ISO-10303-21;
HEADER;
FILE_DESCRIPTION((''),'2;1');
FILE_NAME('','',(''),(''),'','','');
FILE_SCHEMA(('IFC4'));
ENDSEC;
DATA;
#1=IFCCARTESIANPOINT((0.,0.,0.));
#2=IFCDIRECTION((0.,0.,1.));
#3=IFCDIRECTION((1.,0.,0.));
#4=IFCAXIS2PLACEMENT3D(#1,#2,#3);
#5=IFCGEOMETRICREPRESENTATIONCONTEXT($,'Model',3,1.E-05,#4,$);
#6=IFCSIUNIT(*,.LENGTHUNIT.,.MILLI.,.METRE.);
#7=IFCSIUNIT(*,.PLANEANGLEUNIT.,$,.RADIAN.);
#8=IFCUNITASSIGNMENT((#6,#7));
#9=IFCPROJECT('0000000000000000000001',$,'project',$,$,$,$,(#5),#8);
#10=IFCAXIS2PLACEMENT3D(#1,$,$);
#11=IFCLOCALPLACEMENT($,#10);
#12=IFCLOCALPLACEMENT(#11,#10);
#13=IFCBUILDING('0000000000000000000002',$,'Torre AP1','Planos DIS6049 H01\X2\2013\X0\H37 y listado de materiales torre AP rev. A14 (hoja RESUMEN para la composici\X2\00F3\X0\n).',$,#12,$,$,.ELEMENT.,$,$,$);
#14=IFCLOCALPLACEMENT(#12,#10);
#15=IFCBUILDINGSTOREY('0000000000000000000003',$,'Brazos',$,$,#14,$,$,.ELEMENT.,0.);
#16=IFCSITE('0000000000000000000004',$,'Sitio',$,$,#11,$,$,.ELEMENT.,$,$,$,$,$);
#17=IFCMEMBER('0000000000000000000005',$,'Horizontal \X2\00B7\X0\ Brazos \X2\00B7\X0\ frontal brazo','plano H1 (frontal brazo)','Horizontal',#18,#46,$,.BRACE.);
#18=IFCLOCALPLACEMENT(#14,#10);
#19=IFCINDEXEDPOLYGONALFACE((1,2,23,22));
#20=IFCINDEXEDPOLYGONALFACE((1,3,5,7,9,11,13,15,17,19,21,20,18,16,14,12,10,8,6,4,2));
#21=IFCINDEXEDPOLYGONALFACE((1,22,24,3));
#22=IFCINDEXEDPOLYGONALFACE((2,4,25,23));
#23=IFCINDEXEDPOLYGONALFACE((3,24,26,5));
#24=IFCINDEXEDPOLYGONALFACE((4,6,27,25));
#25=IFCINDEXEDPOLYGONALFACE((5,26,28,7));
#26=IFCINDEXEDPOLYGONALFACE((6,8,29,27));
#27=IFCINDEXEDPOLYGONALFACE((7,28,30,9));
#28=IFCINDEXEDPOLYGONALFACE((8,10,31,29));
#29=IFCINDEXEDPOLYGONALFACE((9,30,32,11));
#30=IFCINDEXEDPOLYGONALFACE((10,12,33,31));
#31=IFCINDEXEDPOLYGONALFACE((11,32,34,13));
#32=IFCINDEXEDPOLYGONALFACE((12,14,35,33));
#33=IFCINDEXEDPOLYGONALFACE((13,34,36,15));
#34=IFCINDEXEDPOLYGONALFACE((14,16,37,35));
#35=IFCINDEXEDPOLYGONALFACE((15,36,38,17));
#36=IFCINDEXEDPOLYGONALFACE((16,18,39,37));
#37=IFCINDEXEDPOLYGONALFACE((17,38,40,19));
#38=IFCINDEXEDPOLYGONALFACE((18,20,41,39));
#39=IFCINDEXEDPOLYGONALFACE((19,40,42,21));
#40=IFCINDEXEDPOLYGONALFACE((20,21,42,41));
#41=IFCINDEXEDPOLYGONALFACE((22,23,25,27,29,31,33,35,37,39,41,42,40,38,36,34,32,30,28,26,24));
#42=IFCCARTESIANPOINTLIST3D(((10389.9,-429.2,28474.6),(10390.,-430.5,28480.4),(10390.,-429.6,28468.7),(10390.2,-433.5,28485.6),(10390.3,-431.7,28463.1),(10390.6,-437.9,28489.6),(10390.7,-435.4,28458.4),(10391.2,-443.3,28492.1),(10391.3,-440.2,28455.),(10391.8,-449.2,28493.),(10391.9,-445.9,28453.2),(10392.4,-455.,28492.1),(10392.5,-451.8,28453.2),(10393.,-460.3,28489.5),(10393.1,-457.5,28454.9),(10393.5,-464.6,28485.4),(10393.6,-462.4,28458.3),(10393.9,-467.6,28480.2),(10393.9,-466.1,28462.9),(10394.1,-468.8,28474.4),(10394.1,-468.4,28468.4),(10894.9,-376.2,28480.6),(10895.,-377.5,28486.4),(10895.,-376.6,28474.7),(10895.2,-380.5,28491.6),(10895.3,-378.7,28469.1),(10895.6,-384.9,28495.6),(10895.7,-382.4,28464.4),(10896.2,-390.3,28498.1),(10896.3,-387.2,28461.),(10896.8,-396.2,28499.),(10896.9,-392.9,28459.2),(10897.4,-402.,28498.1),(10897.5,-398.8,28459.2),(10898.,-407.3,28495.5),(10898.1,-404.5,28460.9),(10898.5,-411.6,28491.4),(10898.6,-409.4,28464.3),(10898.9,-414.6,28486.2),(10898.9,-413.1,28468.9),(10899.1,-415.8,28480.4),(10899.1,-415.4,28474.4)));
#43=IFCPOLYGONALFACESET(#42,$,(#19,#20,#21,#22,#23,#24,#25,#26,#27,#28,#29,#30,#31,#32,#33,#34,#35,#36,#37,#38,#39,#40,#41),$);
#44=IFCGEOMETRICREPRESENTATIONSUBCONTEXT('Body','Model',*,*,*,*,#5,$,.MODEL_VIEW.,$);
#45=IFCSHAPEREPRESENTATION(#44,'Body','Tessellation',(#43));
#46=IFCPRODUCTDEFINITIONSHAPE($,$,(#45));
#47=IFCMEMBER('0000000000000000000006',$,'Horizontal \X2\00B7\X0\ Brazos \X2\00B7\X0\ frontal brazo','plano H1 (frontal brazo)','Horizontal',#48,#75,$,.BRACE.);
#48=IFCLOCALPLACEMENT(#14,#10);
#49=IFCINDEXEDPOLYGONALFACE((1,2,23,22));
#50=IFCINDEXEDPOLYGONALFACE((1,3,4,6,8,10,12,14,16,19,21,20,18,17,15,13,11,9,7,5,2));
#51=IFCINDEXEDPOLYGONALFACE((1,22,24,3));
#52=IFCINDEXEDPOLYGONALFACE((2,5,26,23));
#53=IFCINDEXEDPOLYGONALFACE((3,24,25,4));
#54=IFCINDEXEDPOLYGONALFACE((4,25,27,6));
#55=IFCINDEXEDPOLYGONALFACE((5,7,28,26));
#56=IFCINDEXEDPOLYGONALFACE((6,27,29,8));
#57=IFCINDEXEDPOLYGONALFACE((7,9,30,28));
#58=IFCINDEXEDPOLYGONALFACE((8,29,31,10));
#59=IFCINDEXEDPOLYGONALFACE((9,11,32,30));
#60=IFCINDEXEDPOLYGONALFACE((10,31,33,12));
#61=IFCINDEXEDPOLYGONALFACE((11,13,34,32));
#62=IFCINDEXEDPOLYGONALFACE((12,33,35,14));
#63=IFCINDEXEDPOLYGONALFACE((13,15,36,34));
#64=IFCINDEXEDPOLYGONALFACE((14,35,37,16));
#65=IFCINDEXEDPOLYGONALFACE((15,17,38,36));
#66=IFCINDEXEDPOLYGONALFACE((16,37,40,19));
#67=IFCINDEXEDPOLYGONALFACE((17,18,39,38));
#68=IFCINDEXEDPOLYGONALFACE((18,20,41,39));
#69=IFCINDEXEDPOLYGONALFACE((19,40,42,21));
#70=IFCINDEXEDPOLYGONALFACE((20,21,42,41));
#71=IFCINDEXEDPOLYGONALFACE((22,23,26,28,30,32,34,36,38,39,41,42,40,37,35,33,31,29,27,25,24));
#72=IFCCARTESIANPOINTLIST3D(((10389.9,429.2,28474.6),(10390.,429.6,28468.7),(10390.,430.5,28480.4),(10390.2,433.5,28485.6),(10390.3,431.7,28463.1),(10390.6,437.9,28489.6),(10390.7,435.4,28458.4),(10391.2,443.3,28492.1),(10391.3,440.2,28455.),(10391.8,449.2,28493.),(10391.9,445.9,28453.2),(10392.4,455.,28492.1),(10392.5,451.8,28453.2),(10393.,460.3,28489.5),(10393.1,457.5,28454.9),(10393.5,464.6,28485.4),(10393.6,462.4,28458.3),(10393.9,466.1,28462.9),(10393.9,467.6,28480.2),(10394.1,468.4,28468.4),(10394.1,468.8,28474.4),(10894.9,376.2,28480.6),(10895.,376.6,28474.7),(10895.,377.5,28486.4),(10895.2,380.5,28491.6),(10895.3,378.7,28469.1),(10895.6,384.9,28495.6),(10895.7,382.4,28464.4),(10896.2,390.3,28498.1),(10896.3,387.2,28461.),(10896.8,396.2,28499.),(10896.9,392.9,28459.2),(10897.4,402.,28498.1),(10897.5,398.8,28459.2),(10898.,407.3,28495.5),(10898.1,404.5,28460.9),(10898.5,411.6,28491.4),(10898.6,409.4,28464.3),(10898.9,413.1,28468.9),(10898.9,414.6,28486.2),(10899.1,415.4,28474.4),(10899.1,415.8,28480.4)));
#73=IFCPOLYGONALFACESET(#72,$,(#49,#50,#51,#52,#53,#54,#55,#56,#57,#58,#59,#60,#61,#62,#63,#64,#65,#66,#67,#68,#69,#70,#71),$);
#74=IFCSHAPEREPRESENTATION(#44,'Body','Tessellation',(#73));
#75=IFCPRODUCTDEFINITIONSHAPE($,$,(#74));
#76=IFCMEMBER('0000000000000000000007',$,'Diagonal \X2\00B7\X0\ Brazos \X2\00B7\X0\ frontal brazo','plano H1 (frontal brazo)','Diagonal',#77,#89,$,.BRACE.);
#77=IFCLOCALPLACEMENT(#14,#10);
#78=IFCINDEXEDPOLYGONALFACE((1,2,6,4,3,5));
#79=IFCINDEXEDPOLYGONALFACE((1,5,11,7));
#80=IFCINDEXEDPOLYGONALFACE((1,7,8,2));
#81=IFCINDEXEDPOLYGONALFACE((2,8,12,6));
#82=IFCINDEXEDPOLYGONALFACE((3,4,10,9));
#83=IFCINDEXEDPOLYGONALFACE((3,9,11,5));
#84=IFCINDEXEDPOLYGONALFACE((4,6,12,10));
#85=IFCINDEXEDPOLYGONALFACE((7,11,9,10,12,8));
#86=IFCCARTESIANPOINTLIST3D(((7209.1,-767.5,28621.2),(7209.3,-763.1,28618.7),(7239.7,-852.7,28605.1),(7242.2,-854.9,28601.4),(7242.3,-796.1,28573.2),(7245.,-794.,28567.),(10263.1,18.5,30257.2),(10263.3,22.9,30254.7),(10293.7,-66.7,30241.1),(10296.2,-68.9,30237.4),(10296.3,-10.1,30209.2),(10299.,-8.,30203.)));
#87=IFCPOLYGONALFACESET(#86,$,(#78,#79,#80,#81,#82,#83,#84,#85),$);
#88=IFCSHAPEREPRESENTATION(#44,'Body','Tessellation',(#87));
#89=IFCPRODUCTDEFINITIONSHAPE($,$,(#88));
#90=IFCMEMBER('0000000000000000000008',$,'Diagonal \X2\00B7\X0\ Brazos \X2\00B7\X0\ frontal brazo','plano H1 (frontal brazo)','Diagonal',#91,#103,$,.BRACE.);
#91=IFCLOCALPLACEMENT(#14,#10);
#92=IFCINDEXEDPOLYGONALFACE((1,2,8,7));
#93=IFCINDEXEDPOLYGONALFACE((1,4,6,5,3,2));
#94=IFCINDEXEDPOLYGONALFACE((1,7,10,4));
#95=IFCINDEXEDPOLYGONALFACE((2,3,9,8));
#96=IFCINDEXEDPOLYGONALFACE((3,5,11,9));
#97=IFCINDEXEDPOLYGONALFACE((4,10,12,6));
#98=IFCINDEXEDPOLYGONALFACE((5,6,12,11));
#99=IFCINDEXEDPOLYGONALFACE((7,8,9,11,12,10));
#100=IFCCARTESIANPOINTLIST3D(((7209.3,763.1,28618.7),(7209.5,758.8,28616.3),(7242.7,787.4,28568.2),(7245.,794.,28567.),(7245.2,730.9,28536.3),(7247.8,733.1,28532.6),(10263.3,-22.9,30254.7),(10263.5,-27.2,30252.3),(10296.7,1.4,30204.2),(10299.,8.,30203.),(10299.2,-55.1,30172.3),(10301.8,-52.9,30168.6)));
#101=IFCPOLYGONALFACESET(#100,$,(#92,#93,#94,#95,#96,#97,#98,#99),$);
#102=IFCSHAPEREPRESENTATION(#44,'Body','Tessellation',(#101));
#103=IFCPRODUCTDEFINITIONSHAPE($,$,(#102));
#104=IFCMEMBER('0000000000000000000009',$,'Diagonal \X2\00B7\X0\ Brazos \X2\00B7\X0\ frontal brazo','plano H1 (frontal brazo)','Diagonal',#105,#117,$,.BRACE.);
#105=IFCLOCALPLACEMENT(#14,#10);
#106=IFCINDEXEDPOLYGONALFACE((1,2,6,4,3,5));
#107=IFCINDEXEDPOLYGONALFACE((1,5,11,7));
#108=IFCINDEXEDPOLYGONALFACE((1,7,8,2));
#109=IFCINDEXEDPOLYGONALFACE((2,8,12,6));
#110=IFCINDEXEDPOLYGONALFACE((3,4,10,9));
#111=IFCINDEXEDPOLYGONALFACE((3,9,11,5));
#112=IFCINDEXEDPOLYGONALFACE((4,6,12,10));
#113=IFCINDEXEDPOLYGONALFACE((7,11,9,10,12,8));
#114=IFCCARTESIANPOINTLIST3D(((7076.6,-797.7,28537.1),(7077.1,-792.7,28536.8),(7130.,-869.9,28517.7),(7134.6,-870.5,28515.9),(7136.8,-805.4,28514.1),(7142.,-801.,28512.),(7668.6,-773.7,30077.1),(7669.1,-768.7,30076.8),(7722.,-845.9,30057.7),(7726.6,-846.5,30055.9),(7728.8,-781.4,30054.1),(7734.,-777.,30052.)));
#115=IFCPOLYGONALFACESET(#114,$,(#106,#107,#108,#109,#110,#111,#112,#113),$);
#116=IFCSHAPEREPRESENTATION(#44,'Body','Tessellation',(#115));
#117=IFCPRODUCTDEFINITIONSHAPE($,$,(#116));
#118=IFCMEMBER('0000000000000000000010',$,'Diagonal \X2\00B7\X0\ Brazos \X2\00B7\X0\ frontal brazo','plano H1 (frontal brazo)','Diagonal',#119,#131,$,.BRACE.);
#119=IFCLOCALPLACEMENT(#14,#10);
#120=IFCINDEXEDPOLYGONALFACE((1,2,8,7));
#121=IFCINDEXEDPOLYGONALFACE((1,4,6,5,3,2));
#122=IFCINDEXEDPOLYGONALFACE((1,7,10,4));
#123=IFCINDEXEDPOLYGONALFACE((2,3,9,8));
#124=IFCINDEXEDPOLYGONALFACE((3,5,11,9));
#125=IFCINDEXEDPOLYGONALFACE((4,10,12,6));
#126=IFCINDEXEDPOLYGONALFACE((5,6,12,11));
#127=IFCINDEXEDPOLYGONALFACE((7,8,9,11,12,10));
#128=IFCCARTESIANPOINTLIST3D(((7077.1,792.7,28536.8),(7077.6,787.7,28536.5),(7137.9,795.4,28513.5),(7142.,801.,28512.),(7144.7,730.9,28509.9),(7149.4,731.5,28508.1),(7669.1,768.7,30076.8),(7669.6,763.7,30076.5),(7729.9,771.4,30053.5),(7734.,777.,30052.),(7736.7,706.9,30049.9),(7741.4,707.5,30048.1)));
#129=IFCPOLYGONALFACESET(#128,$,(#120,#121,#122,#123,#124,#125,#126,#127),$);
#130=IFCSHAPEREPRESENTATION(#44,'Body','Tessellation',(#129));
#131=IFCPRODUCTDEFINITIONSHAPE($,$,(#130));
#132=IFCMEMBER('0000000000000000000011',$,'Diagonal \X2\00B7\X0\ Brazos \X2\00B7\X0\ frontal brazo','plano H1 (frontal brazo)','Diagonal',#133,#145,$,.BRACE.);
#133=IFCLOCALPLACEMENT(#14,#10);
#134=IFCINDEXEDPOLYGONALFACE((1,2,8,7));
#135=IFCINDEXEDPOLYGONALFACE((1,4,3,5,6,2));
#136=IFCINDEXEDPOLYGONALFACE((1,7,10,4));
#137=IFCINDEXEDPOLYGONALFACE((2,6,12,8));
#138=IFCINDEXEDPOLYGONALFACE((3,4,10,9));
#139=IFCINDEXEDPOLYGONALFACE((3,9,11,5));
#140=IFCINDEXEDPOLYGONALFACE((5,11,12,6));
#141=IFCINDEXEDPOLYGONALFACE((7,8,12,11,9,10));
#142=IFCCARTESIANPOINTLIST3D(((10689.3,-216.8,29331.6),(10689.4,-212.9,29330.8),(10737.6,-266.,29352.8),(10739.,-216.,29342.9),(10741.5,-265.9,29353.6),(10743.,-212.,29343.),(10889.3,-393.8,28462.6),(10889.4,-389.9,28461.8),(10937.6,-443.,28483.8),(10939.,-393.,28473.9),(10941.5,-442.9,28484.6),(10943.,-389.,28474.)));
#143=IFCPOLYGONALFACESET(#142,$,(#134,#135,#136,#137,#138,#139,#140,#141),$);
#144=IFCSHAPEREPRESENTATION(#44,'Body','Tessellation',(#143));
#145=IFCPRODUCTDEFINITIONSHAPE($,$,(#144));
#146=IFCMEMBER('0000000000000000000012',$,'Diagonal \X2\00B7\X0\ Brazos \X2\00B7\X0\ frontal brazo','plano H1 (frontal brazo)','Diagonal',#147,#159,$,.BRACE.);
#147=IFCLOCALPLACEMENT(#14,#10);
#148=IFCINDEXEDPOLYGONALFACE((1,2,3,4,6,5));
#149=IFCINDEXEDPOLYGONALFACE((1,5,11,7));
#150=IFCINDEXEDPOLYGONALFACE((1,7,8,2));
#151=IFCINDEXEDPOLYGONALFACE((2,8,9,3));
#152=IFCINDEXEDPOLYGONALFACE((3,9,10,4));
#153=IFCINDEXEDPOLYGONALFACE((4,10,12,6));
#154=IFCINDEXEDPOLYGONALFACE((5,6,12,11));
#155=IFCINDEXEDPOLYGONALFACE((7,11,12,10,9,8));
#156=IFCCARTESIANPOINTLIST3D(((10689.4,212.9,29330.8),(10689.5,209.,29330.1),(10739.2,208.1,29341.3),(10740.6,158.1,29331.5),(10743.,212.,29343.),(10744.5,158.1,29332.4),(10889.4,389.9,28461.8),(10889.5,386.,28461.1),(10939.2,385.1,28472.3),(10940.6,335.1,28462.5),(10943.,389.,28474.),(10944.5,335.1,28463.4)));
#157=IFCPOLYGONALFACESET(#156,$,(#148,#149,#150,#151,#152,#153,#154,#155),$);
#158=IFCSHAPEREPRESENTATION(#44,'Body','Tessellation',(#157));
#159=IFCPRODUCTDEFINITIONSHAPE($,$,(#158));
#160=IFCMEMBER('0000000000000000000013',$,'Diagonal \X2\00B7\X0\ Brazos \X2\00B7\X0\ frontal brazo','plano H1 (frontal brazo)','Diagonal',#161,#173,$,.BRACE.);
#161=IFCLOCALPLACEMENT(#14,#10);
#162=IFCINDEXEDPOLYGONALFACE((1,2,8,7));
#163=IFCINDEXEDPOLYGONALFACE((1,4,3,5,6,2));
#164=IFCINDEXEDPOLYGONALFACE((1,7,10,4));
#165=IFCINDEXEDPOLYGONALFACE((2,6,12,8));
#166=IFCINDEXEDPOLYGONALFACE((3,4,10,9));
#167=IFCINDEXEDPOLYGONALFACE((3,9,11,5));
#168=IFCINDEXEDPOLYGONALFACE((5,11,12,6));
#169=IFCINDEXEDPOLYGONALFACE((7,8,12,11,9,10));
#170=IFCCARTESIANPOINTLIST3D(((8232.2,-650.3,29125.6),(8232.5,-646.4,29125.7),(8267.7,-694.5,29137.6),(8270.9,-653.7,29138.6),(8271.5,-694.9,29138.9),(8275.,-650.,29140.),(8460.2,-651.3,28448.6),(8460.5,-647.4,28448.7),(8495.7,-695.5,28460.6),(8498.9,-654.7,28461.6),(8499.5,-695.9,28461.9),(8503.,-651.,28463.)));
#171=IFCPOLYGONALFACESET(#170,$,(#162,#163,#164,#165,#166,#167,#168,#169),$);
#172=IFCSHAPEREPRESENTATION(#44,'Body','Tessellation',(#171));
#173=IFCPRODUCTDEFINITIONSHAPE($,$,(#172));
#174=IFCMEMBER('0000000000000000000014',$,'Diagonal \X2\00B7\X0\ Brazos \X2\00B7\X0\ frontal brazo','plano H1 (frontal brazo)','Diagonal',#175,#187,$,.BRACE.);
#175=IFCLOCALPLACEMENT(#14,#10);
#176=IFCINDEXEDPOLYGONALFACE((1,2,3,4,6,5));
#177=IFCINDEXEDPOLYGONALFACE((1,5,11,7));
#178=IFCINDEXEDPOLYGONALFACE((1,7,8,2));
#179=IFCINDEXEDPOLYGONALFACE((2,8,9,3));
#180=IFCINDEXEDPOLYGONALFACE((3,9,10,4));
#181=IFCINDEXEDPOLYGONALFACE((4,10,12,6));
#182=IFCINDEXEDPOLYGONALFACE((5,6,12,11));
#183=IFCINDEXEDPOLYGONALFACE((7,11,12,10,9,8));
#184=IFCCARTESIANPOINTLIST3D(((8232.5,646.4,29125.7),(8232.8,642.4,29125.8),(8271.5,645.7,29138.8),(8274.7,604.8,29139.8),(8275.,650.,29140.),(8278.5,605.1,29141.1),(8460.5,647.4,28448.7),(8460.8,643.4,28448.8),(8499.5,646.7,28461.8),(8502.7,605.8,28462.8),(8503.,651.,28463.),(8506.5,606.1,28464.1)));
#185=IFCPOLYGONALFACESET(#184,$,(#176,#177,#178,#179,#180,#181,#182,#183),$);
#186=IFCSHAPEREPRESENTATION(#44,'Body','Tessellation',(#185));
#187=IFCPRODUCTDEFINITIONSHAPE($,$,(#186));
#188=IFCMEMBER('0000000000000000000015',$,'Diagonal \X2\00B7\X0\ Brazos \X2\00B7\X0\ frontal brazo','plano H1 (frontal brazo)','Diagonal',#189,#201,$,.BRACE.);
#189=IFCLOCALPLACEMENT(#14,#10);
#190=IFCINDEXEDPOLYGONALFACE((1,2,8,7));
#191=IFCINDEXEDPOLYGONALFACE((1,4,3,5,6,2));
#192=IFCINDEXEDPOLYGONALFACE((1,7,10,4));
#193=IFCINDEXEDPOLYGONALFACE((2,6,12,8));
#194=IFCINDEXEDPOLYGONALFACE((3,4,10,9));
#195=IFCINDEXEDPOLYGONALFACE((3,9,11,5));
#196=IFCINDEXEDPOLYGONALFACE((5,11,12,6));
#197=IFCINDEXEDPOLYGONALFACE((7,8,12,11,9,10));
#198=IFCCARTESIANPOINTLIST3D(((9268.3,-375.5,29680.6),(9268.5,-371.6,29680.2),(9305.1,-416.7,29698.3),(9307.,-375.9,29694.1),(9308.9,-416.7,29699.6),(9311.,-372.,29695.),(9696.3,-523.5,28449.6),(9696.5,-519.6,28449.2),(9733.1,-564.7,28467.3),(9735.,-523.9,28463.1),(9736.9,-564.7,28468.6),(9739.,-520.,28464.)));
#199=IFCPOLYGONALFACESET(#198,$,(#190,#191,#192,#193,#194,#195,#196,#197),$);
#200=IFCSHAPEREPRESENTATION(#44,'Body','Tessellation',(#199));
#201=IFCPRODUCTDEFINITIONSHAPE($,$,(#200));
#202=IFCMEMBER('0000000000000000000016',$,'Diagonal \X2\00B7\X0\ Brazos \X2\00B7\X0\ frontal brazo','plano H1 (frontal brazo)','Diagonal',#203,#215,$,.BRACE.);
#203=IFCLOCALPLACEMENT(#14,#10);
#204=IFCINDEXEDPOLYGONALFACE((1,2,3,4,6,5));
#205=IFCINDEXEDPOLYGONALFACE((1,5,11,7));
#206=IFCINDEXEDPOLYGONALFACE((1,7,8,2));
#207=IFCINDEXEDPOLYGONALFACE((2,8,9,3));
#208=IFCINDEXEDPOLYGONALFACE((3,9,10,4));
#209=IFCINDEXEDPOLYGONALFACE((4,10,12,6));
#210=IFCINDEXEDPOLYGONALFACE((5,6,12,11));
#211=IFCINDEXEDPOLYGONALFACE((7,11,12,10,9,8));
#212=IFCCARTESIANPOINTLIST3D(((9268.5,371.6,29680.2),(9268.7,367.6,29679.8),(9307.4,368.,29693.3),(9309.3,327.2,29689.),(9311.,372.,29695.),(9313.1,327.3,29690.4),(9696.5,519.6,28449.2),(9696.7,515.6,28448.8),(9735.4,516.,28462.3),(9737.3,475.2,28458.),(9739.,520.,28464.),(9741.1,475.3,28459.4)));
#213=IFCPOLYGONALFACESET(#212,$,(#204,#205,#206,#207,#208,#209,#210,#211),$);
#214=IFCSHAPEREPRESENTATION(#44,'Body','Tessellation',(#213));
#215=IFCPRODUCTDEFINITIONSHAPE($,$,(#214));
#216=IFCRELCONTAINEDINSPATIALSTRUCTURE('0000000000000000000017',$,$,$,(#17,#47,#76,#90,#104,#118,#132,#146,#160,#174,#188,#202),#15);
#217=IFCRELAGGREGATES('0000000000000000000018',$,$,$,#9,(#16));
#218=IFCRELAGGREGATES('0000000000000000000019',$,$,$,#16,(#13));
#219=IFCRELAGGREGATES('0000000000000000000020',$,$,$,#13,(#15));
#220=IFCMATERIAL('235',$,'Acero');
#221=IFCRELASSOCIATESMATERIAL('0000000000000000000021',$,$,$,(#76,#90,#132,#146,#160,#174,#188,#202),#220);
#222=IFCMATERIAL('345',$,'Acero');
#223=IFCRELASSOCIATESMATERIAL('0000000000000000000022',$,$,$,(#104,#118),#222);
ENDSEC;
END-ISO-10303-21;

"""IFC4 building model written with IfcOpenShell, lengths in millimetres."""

from ifc_helpers import new_model, si_unit, frame, frame_2d, origin, origin_with_axes, place, context, subcontext, project, spatial, circle, l_section, extrude, material, element, save


model = new_model("IFC4")

# Units and contexts
model_context = context("Model", 3, precision=1e-05, world=origin_with_axes())
body_context = subcontext(model_context, "Body", "Model", "MODEL_VIEW")
ifc_project = project(units=[si_unit("LENGTHUNIT", "METRE", prefix="MILLI"), si_unit("PLANEANGLEUNIT", "RADIAN")], contexts=[model_context])

# Site, building, storey
site_placement = place(None, origin())
site = spatial("IfcSite", under=ifc_project, at=site_placement, Name="Sitio", CompositionType="ELEMENT")
building_placement = place(site_placement, origin())
building = spatial("IfcBuilding", under=site, at=building_placement, Name="Torre AP1", Description="Planos DIS6049 H01–H37 y listado de materiales torre AP rev. A14 (hoja RESUMEN para la composición).", CompositionType="ELEMENT")
storey_placement = place(building_placement, origin())
storey = spatial("IfcBuildingStorey", under=building, at=storey_placement, Name="Brazos", CompositionType="ELEMENT", Elevation=0.0)

# Members
for number, where, z_axis, x_axis, name in (
    (1, (10392.0, -449.0, 28473.0), (0.994468, 0.10437, 0.011815), (-0.104986, 0.991163, 0.081074), "Horizontal · Brazos · frontal brazo"),
    (2, (10392.0, 449.0, 28473.0), (0.994468, -0.10437, 0.011815), (-0.104986, -0.991163, 0.081074), "Horizontal · Brazos · frontal brazo"),
):
    element("IfcMember", number, at=place(storey_placement, frame(where, z_axis=z_axis, x_axis=x_axis)), inside=storey, Name=name, Description="plano H1 (frontal brazo)", ObjectType="Horizontal", PredefinedType="BRACE", context=body_context, shape_type="SweptSolid", body=[
        extrude(circle(Radius=20.0), None, (0.0, 0.0, 1.0), 507.8),
    ])
ifc_material_1 = material(Name="235", Category="Acero")
for number, where, z_axis, x_axis, name in (
    (3, (7245.0, -794.0, 28567.0), (0.859644, 0.221244, 0.460503), (-0.509345, 0.441284, 0.738808), "Diagonal · Brazos · frontal brazo"),
    (4, (7245.0, 794.0, 28567.0), (0.859644, -0.221244, 0.460503), (-0.509345, -0.441284, 0.738808), "Diagonal · Brazos · frontal brazo"),
):
    element("IfcMember", number, at=place(storey_placement, frame(where, z_axis=z_axis, x_axis=x_axis)), inside=storey, material=ifc_material_1, Name=name, Description="plano H1 (frontal brazo)", ObjectType="Diagonal", PredefinedType="BRACE", context=body_context, shape_type="SweptSolid", body=[
        extrude(l_section(Depth=70.0, Width=70.0, Thickness=5.0, at=frame_2d((35.0, 35.0))), None, (0.0, 0.0, 1.0), 3552.6),
    ])
ifc_material_2 = material(Name="345", Category="Acero")
for number, where, z_axis, x_axis, name in (
    (5, (7142.0, -801.0, 28512.0), (0.358779, 0.014545, 0.933309), (-0.927462, 0.118373, 0.354686), "Diagonal · Brazos · frontal brazo"),
    (6, (7142.0, 801.0, 28512.0), (0.358779, -0.014545, 0.933309), (-0.927462, -0.118373, 0.354686), "Diagonal · Brazos · frontal brazo"),
):
    element("IfcMember", number, at=place(storey_placement, frame(where, z_axis=z_axis, x_axis=x_axis)), inside=storey, material=ifc_material_2, Name=name, Description="plano H1 (frontal brazo)", ObjectType="Diagonal", PredefinedType="BRACE", context=body_context, shape_type="SweptSolid", body=[
        extrude(l_section(Depth=70.0, Width=70.0, Thickness=5.0, at=frame_2d((35.0, 35.0))), None, (0.0, 0.0, 1.0), 1650.0),
    ])
for number, where, z_axis, x_axis, name in (
    (7, (10943.0, -389.0, 28474.0), (-0.219994, 0.194695, 0.955875), (-0.975122, -0.016589, -0.221045), "Diagonal · Brazos · frontal brazo"),
    (8, (10943.0, 389.0, 28474.0), (-0.219994, -0.194695, 0.955875), (-0.975122, 0.016589, -0.221045), "Diagonal · Brazos · frontal brazo"),
):
    element("IfcMember", number, at=place(storey_placement, frame(where, z_axis=z_axis, x_axis=x_axis)), inside=storey, material=ifc_material_1, Name=name, Description="plano H1 (frontal brazo)", ObjectType="Diagonal", PredefinedType="BRACE", context=body_context, shape_type="SweptSolid", body=[
        extrude(l_section(Depth=55.0, Width=55.0, Thickness=4.0, at=frame_2d((27.5, 27.5))), None, (0.0, 0.0, 1.0), 909.1),
    ])
for number, where, z_axis, x_axis, name in (
    (9, (8503.0, -651.0, 28463.0), (-0.319166, 0.0014, 0.947698), (-0.944542, 0.081082, -0.318223), "Diagonal · Brazos · frontal brazo"),
    (10, (8503.0, 651.0, 28463.0), (-0.319166, -0.0014, 0.947698), (-0.944542, -0.081082, -0.318223), "Diagonal · Brazos · frontal brazo"),
):
    element("IfcMember", number, at=place(storey_placement, frame(where, z_axis=z_axis, x_axis=x_axis)), inside=storey, material=ifc_material_1, Name=name, Description="plano H1 (frontal brazo)", ObjectType="Diagonal", PredefinedType="BRACE", context=body_context, shape_type="SweptSolid", body=[
        extrude(l_section(Depth=45.0, Width=45.0, Thickness=4.0, at=frame_2d((22.5, 22.5))), None, (0.0, 0.0, 1.0), 714.4),
    ])
for number, where, z_axis, x_axis, name in (
    (11, (9739.0, -520.0, 28464.0), (-0.326304, 0.112834, 0.938506), (-0.944119, 0.009962, -0.329454), "Diagonal · Brazos · frontal brazo"),
    (12, (9739.0, 520.0, 28464.0), (-0.326304, -0.112834, 0.938506), (-0.944119, -0.009962, -0.329454), "Diagonal · Brazos · frontal brazo"),
):
    element("IfcMember", number, at=place(storey_placement, frame(where, z_axis=z_axis, x_axis=x_axis)), inside=storey, material=ifc_material_1, Name=name, Description="plano H1 (frontal brazo)", ObjectType="Diagonal", PredefinedType="BRACE", context=body_context, shape_type="SweptSolid", body=[
        extrude(l_section(Depth=45.0, Width=45.0, Thickness=4.0, at=frame_2d((22.5, 22.5))), None, (0.0, 0.0, 1.0), 1311.7),
    ])

save(model, "model.ifc")
